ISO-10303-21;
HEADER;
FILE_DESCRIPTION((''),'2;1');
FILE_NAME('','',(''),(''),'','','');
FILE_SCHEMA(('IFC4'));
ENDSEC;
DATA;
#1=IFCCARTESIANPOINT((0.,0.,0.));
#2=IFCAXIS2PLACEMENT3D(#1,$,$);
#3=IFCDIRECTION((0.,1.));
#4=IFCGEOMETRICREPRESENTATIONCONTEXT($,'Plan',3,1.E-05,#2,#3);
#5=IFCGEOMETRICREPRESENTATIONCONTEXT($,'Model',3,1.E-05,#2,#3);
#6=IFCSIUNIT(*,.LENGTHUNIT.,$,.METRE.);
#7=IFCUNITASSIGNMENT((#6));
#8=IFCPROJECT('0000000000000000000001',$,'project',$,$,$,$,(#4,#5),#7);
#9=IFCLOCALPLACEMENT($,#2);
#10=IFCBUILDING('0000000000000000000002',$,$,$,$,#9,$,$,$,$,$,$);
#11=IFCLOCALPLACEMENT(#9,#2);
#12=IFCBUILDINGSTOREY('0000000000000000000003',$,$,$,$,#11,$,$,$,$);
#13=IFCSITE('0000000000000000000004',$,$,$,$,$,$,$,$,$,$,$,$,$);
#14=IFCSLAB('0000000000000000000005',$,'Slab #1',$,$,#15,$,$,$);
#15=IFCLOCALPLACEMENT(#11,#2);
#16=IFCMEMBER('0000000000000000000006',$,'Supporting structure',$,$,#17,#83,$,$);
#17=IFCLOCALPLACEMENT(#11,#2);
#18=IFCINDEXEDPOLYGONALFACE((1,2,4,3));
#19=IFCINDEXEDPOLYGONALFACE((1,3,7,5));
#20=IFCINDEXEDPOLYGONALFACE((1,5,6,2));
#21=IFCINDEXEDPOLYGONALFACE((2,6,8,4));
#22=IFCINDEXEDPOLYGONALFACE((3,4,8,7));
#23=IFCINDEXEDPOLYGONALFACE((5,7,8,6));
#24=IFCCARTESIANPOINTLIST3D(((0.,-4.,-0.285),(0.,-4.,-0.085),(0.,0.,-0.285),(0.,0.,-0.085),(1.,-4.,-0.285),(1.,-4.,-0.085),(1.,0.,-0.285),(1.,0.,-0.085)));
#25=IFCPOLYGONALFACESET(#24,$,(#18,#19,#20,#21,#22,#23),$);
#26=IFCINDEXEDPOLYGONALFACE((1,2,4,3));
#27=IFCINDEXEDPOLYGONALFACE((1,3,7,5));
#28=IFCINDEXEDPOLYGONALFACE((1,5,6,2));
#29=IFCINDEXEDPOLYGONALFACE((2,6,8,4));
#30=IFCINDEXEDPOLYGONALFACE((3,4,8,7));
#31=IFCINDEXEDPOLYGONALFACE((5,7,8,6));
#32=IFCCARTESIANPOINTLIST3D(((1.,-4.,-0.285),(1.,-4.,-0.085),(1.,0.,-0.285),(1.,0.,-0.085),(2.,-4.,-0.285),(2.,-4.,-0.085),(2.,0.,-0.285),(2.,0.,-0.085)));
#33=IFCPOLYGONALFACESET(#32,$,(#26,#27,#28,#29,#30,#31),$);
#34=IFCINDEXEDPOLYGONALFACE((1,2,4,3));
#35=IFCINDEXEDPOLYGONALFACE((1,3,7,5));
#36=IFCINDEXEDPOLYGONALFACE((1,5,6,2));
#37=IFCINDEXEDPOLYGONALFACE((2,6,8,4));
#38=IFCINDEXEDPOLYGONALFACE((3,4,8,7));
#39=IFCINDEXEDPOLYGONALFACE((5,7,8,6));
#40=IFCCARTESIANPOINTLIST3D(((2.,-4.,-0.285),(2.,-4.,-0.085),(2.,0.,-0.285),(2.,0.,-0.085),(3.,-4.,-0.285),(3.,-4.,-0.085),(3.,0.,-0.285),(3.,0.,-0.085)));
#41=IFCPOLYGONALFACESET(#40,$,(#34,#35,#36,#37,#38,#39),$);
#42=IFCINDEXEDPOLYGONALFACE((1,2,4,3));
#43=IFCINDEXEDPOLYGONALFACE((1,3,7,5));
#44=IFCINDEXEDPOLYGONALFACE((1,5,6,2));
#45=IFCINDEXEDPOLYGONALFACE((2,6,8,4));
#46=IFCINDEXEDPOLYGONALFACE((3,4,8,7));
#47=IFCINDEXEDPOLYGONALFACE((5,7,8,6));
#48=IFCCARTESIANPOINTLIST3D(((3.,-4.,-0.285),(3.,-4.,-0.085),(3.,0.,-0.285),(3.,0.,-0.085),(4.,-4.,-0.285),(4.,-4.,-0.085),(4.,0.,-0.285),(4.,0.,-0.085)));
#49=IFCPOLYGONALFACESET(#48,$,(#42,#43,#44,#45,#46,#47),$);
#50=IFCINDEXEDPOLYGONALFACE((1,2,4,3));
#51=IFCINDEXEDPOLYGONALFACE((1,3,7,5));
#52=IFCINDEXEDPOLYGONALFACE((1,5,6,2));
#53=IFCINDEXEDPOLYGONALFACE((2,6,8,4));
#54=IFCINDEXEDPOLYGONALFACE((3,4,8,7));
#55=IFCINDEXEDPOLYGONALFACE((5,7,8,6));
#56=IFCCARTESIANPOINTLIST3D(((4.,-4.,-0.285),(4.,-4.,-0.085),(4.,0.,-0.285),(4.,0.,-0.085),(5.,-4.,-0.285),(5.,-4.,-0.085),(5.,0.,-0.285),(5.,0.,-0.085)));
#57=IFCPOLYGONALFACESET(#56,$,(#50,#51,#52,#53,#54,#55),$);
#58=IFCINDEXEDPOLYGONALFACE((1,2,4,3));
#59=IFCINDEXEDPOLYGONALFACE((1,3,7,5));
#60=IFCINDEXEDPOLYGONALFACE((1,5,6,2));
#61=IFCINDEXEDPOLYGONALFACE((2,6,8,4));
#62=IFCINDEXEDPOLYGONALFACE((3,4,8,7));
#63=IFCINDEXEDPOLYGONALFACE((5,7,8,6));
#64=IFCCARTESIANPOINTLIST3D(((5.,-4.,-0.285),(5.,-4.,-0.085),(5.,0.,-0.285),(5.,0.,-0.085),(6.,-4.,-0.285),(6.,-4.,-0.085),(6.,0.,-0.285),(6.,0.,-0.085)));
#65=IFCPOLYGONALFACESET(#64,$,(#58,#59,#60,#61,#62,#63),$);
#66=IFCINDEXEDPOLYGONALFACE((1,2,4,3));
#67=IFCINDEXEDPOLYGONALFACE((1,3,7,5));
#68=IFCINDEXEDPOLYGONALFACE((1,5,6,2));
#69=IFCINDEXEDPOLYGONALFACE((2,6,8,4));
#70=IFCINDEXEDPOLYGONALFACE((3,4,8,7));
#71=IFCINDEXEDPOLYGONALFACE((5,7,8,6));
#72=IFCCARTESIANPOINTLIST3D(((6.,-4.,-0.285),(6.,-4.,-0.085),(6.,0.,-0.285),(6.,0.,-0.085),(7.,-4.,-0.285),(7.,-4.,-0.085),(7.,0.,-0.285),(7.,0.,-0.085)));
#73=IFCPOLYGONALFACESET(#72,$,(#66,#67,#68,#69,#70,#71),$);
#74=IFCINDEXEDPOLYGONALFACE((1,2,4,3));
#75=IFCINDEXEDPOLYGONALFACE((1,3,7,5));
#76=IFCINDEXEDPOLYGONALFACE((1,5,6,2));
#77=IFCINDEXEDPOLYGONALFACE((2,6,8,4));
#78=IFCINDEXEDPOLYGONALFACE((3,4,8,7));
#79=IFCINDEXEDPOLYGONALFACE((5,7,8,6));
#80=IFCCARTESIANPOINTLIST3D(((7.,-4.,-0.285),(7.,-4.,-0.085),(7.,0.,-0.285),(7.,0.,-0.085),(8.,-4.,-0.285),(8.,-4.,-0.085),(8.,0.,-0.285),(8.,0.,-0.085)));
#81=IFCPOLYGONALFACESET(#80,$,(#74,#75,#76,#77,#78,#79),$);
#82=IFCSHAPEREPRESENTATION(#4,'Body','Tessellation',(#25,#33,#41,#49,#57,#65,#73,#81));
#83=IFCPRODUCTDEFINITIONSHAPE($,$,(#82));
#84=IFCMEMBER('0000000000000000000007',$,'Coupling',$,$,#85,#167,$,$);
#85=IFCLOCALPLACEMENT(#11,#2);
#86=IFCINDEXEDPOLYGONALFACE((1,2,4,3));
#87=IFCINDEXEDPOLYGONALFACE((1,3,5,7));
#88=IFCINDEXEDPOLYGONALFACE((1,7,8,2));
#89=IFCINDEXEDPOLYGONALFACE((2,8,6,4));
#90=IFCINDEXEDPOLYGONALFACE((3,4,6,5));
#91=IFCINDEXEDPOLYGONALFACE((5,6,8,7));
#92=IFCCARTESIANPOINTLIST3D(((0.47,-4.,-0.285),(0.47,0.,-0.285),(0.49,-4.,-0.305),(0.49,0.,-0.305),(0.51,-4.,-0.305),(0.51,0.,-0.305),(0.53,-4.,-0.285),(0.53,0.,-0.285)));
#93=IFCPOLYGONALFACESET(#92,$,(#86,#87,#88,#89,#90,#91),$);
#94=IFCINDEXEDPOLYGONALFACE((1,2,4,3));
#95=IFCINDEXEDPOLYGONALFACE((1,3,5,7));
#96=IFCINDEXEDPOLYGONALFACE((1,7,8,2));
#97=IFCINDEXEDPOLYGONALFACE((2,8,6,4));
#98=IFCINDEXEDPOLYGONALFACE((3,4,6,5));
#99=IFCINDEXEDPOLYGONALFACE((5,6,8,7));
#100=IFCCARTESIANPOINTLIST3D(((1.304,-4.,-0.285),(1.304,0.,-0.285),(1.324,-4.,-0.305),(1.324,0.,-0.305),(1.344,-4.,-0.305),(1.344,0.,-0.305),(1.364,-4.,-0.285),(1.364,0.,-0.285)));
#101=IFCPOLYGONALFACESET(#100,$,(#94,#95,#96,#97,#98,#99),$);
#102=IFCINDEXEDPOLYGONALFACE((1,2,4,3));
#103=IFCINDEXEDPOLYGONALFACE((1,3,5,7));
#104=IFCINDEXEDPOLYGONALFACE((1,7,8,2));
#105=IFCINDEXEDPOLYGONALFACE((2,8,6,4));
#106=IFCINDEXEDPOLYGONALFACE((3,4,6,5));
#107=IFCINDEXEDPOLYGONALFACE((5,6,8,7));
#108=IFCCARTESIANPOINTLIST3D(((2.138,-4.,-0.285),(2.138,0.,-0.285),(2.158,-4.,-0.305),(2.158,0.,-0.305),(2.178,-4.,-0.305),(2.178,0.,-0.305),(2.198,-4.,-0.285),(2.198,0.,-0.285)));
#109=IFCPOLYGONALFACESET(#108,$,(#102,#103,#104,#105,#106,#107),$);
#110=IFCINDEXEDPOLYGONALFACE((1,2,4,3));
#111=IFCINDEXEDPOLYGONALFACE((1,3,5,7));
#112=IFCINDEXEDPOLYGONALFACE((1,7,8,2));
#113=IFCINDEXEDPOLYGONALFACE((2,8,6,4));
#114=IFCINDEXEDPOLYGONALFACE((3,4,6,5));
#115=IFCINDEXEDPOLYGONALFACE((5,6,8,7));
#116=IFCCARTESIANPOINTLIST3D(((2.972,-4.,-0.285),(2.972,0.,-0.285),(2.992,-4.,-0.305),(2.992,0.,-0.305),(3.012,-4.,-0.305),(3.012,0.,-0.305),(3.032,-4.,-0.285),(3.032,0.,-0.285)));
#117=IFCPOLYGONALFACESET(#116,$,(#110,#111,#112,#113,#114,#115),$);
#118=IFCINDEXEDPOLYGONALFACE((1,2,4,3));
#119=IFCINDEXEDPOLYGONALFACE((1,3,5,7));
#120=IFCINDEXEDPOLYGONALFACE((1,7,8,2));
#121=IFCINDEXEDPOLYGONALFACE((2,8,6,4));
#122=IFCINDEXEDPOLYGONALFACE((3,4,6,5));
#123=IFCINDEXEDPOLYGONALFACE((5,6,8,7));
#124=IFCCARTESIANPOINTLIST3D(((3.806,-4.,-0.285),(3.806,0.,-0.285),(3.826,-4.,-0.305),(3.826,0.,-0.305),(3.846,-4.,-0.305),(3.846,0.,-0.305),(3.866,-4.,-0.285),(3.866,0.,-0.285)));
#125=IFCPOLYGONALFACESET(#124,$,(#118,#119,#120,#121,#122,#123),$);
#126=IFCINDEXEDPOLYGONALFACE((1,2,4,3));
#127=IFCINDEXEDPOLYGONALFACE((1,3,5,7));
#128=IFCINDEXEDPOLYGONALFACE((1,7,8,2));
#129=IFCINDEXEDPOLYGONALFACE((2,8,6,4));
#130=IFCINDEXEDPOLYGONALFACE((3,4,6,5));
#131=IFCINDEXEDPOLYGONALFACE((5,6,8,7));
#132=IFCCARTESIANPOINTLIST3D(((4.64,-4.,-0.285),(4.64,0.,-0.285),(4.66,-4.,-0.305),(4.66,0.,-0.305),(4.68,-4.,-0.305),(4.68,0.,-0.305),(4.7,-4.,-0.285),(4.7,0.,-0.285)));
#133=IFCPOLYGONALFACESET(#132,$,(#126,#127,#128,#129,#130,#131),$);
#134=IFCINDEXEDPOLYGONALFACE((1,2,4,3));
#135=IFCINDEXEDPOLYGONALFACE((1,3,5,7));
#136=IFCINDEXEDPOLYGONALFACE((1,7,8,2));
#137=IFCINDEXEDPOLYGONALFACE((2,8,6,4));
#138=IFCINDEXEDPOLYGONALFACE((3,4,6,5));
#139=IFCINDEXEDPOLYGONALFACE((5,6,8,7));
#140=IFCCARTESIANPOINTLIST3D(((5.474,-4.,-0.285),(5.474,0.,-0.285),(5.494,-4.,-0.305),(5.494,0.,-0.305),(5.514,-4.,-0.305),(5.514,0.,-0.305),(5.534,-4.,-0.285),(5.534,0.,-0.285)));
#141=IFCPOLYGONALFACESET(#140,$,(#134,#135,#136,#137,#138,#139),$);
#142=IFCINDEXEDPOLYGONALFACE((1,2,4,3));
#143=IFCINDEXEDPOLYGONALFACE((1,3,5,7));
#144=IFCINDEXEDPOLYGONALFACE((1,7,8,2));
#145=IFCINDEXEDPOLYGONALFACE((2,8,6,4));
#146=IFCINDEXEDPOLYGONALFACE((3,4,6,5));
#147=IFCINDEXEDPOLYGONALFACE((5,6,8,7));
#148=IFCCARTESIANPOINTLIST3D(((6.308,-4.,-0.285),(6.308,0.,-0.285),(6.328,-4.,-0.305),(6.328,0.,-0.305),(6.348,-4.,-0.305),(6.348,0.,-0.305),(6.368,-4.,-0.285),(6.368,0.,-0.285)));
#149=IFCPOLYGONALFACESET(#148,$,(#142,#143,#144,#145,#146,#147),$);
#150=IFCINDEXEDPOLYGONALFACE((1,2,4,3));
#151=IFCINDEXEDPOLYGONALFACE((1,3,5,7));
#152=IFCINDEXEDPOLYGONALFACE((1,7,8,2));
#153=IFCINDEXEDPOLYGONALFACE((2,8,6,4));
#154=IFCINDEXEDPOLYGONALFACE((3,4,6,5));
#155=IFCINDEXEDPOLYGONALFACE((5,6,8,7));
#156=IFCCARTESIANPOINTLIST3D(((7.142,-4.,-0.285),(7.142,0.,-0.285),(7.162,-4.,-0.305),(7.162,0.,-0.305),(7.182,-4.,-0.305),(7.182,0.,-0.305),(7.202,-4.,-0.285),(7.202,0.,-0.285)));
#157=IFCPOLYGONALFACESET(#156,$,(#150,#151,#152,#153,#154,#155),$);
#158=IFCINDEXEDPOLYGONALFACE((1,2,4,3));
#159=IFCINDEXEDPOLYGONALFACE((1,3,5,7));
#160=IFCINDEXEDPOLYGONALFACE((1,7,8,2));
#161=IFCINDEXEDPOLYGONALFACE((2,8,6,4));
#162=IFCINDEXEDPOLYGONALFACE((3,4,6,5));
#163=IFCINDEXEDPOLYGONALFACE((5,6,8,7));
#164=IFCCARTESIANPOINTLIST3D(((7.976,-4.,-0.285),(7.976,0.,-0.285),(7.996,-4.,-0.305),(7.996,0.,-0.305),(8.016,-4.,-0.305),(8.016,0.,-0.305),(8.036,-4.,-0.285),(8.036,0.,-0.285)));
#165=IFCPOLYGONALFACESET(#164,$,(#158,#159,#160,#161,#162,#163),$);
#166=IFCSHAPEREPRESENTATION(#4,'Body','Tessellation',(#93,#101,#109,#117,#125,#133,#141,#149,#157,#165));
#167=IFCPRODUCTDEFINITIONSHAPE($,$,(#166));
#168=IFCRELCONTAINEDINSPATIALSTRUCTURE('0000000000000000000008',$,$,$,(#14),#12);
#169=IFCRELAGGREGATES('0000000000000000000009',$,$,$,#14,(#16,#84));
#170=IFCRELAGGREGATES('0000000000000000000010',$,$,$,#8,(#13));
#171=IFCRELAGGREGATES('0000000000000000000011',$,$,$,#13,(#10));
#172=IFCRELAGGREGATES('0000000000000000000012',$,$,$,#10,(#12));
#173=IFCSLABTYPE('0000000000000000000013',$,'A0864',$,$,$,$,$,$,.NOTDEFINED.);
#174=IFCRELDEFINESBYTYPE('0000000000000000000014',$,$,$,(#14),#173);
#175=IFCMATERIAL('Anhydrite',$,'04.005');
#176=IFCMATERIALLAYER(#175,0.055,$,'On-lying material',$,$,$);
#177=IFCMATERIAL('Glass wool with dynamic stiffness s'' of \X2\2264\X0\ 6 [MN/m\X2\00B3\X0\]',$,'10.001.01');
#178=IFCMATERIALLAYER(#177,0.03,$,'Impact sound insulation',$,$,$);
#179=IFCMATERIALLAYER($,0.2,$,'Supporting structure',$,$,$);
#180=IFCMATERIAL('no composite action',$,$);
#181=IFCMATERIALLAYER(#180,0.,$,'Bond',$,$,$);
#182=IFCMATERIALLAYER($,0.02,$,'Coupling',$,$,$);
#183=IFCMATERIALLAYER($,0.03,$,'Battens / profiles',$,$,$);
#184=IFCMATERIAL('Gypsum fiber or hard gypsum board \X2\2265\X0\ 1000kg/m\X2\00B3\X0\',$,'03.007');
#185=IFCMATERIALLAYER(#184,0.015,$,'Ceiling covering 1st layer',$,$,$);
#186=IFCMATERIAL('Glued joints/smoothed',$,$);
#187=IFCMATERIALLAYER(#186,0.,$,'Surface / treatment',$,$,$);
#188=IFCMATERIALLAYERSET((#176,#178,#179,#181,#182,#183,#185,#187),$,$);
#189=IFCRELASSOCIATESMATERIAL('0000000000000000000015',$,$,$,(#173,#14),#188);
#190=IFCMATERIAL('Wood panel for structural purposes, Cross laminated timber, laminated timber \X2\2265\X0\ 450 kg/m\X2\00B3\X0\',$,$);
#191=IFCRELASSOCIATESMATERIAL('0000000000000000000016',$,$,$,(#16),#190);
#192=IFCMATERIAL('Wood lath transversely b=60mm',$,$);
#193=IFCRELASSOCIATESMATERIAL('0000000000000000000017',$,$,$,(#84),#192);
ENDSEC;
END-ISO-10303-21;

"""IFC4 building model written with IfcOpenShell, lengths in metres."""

from ifc_helpers import new_model, si_unit, direction, frame, frame_2d, origin, place, context, project, spatial, polyline, rectangle, outline, extrude, material, layer, layer_set, type_object, element, aggregate, save


model = new_model("IFC4")

# Units and contexts
plan_context = context("Plan", 3, precision=1e-05, world=origin(), true_north=direction((0.0, 1.0)))
model_context = context("Model", 3, precision=1e-05, world=origin(), true_north=direction((0.0, 1.0)))
ifc_project = project(units=[si_unit("LENGTHUNIT", "METRE")], contexts=[plan_context, model_context])

# Site, building, storey
site = spatial("IfcSite", under=ifc_project)
building_placement = place(None, origin())
building = spatial("IfcBuilding", under=site, at=building_placement)
storey_placement = place(building_placement, origin())
storey = spatial("IfcBuildingStorey", under=building, at=storey_placement)

# Slab, members
ifc_material_1 = material(Name="Anhydrite", Category="04.005")
ifc_layer_1 = layer(ifc_material_1, 0.055, Name="On-lying material")
ifc_material_2 = material(Name="Glass wool with dynamic stiffness s' of ≤ 6 [MN/m³]", Category="10.001.01")
ifc_layer_2 = layer(ifc_material_2, 0.03, Name="Impact sound insulation")
ifc_layer_3 = layer(None, 0.2, Name="Supporting structure")
ifc_material_3 = material(Name="no composite action")
ifc_layer_4 = layer(ifc_material_3, 0.0, Name="Bond")
ifc_layer_5 = layer(None, 0.02, Name="Coupling")
ifc_layer_6 = layer(None, 0.03, Name="Battens / profiles")
ifc_material_4 = material(Name="Gypsum fiber or hard gypsum board ≥ 1000kg/m³", Category="03.007")
ifc_layer_7 = layer(ifc_material_4, 0.015, Name="Ceiling covering 1st layer")
ifc_material_5 = material(Name="Glued joints/smoothed")
ifc_layer_8 = layer(ifc_material_5, 0.0, Name="Surface / treatment")
ifc_layer_set = layer_set([ifc_layer_1, ifc_layer_2, ifc_layer_3, ifc_layer_4, ifc_layer_5, ifc_layer_6, ifc_layer_7, ifc_layer_8])
slab_type = type_object("IfcSlabType", Name="A0864", PredefinedType="NOTDEFINED", material=ifc_layer_set)
slab_placement = place(None, frame((0.0, 0.0, 0.0), z_axis=(0.0, 0.0, -1.0), x_axis=(1.0, 0.0, 0.0)))
slab = element("IfcSlab", 1, at=slab_placement, inside=storey, type_object=slab_type, material=ifc_layer_set, Name="Slab #1")
ifc_material_6 = material(Name="Wood panel for structural purposes, Cross laminated timber, laminated timber ≥ 450 kg/m³")
member_1_placement = place(slab_placement, origin())
member_1 = element("IfcMember", 2, at=member_1_placement, material=ifc_material_6, Name="Supporting structure", context=plan_context, shape_type="SweptSolid", body=[
    extrude(rectangle(XDim=1.0, YDim=0.2, at=frame_2d((0.5, 0.1), x_axis=(1.0, 0.0))), frame((0.0, 4.0, 0.085), z_axis=(0.0, -1.0, 0.0), x_axis=(1.0, 0.0, 0.0)), (0.0, 0.0, 1.0), 4.0),
    extrude(rectangle(XDim=1.0, YDim=0.2, at=frame_2d((0.5, 0.1), x_axis=(1.0, 0.0))), frame((1.0, 4.0, 0.085), z_axis=(0.0, -1.0, 0.0), x_axis=(1.0, 0.0, 0.0)), (0.0, 0.0, 1.0), 4.0),
    extrude(rectangle(XDim=1.0, YDim=0.2, at=frame_2d((0.5, 0.1), x_axis=(1.0, 0.0))), frame((2.0, 4.0, 0.085), z_axis=(0.0, -1.0, 0.0), x_axis=(1.0, 0.0, 0.0)), (0.0, 0.0, 1.0), 4.0),
    extrude(rectangle(XDim=1.0, YDim=0.2, at=frame_2d((0.5, 0.1), x_axis=(1.0, 0.0))), frame((3.0, 4.0, 0.085), z_axis=(0.0, -1.0, 0.0), x_axis=(1.0, 0.0, 0.0)), (0.0, 0.0, 1.0), 4.0),
    extrude(rectangle(XDim=1.0, YDim=0.2, at=frame_2d((0.5, 0.1), x_axis=(1.0, 0.0))), frame((4.0, 4.0, 0.085), z_axis=(0.0, -1.0, 0.0), x_axis=(1.0, 0.0, 0.0)), (0.0, 0.0, 1.0), 4.0),
    extrude(rectangle(XDim=1.0, YDim=0.2, at=frame_2d((0.5, 0.1), x_axis=(1.0, 0.0))), frame((5.0, 4.0, 0.085), z_axis=(0.0, -1.0, 0.0), x_axis=(1.0, 0.0, 0.0)), (0.0, 0.0, 1.0), 4.0),
    extrude(rectangle(XDim=1.0, YDim=0.2, at=frame_2d((0.5, 0.1), x_axis=(1.0, 0.0))), frame((6.0, 4.0, 0.085), z_axis=(0.0, -1.0, 0.0), x_axis=(1.0, 0.0, 0.0)), (0.0, 0.0, 1.0), 4.0),
    extrude(rectangle(XDim=1.0, YDim=0.2, at=frame_2d((0.5, 0.1), x_axis=(1.0, 0.0))), frame((7.0, 4.0, 0.085), z_axis=(0.0, -1.0, 0.0), x_axis=(1.0, 0.0, 0.0)), (0.0, 0.0, 1.0), 4.0),
])
ifc_material_7 = material(Name="Wood lath transversely b=60mm")
member_2_placement = place(slab_placement, origin())
member_2 = element("IfcMember", 3, at=member_2_placement, material=ifc_material_7, Name="Coupling", context=plan_context, shape_type="SweptSolid", body=[
    extrude(outline(polyline([(0.0, 0.0), (0.06, 0.0), (0.04, 0.02), (0.02, 0.02), (0.0, 0.0)])), frame((0.47, 4.0, 0.285), z_axis=(0.0, -1.0, 0.0), x_axis=(1.0, 0.0, 0.0)), (0.0, 0.0, 1.0), 4.0),
    extrude(outline(polyline([(0.0, 0.0), (0.06, 0.0), (0.04, 0.02), (0.02, 0.02), (0.0, 0.0)])), frame((1.304, 4.0, 0.285), z_axis=(0.0, -1.0, 0.0), x_axis=(1.0, 0.0, 0.0)), (0.0, 0.0, 1.0), 4.0),
    extrude(outline(polyline([(0.0, 0.0), (0.06, 0.0), (0.04, 0.02), (0.02, 0.02), (0.0, 0.0)])), frame((2.138, 4.0, 0.285), z_axis=(0.0, -1.0, 0.0), x_axis=(1.0, 0.0, 0.0)), (0.0, 0.0, 1.0), 4.0),
    extrude(outline(polyline([(0.0, 0.0), (0.06, 0.0), (0.04, 0.02), (0.02, 0.02), (0.0, 0.0)])), frame((2.972, 4.0, 0.285), z_axis=(0.0, -1.0, 0.0), x_axis=(1.0, 0.0, 0.0)), (0.0, 0.0, 1.0), 4.0),
    extrude(outline(polyline([(0.0, 0.0), (0.06, 0.0), (0.04, 0.02), (0.02, 0.02), (0.0, 0.0)])), frame((3.806, 4.0, 0.285), z_axis=(0.0, -1.0, 0.0), x_axis=(1.0, 0.0, 0.0)), (0.0, 0.0, 1.0), 4.0),
    extrude(outline(polyline([(0.0, 0.0), (0.06, 0.0), (0.04, 0.02), (0.02, 0.02), (0.0, 0.0)])), frame((4.64, 4.0, 0.285), z_axis=(0.0, -1.0, 0.0), x_axis=(1.0, 0.0, 0.0)), (0.0, 0.0, 1.0), 4.0),
    extrude(outline(polyline([(0.0, 0.0), (0.06, 0.0), (0.04, 0.02), (0.02, 0.02), (0.0, 0.0)])), frame((5.474, 4.0, 0.285), z_axis=(0.0, -1.0, 0.0), x_axis=(1.0, 0.0, 0.0)), (0.0, 0.0, 1.0), 4.0),
    extrude(outline(polyline([(0.0, 0.0), (0.06, 0.0), (0.04, 0.02), (0.02, 0.02), (0.0, 0.0)])), frame((6.308, 4.0, 0.285), z_axis=(0.0, -1.0, 0.0), x_axis=(1.0, 0.0, 0.0)), (0.0, 0.0, 1.0), 4.0),
    extrude(outline(polyline([(0.0, 0.0), (0.06, 0.0), (0.04, 0.02), (0.02, 0.02), (0.0, 0.0)])), frame((7.142, 4.0, 0.285), z_axis=(0.0, -1.0, 0.0), x_axis=(1.0, 0.0, 0.0)), (0.0, 0.0, 1.0), 4.0),
    extrude(outline(polyline([(0.0, 0.0), (0.06, 0.0), (0.04, 0.02), (0.02, 0.02), (0.0, 0.0)])), frame((7.976, 4.0, 0.285), z_axis=(0.0, -1.0, 0.0), x_axis=(1.0, 0.0, 0.0)), (0.0, 0.0, 1.0), 4.0),
])
aggregate(slab, [member_1, member_2])

save(model, "model.ifc")
